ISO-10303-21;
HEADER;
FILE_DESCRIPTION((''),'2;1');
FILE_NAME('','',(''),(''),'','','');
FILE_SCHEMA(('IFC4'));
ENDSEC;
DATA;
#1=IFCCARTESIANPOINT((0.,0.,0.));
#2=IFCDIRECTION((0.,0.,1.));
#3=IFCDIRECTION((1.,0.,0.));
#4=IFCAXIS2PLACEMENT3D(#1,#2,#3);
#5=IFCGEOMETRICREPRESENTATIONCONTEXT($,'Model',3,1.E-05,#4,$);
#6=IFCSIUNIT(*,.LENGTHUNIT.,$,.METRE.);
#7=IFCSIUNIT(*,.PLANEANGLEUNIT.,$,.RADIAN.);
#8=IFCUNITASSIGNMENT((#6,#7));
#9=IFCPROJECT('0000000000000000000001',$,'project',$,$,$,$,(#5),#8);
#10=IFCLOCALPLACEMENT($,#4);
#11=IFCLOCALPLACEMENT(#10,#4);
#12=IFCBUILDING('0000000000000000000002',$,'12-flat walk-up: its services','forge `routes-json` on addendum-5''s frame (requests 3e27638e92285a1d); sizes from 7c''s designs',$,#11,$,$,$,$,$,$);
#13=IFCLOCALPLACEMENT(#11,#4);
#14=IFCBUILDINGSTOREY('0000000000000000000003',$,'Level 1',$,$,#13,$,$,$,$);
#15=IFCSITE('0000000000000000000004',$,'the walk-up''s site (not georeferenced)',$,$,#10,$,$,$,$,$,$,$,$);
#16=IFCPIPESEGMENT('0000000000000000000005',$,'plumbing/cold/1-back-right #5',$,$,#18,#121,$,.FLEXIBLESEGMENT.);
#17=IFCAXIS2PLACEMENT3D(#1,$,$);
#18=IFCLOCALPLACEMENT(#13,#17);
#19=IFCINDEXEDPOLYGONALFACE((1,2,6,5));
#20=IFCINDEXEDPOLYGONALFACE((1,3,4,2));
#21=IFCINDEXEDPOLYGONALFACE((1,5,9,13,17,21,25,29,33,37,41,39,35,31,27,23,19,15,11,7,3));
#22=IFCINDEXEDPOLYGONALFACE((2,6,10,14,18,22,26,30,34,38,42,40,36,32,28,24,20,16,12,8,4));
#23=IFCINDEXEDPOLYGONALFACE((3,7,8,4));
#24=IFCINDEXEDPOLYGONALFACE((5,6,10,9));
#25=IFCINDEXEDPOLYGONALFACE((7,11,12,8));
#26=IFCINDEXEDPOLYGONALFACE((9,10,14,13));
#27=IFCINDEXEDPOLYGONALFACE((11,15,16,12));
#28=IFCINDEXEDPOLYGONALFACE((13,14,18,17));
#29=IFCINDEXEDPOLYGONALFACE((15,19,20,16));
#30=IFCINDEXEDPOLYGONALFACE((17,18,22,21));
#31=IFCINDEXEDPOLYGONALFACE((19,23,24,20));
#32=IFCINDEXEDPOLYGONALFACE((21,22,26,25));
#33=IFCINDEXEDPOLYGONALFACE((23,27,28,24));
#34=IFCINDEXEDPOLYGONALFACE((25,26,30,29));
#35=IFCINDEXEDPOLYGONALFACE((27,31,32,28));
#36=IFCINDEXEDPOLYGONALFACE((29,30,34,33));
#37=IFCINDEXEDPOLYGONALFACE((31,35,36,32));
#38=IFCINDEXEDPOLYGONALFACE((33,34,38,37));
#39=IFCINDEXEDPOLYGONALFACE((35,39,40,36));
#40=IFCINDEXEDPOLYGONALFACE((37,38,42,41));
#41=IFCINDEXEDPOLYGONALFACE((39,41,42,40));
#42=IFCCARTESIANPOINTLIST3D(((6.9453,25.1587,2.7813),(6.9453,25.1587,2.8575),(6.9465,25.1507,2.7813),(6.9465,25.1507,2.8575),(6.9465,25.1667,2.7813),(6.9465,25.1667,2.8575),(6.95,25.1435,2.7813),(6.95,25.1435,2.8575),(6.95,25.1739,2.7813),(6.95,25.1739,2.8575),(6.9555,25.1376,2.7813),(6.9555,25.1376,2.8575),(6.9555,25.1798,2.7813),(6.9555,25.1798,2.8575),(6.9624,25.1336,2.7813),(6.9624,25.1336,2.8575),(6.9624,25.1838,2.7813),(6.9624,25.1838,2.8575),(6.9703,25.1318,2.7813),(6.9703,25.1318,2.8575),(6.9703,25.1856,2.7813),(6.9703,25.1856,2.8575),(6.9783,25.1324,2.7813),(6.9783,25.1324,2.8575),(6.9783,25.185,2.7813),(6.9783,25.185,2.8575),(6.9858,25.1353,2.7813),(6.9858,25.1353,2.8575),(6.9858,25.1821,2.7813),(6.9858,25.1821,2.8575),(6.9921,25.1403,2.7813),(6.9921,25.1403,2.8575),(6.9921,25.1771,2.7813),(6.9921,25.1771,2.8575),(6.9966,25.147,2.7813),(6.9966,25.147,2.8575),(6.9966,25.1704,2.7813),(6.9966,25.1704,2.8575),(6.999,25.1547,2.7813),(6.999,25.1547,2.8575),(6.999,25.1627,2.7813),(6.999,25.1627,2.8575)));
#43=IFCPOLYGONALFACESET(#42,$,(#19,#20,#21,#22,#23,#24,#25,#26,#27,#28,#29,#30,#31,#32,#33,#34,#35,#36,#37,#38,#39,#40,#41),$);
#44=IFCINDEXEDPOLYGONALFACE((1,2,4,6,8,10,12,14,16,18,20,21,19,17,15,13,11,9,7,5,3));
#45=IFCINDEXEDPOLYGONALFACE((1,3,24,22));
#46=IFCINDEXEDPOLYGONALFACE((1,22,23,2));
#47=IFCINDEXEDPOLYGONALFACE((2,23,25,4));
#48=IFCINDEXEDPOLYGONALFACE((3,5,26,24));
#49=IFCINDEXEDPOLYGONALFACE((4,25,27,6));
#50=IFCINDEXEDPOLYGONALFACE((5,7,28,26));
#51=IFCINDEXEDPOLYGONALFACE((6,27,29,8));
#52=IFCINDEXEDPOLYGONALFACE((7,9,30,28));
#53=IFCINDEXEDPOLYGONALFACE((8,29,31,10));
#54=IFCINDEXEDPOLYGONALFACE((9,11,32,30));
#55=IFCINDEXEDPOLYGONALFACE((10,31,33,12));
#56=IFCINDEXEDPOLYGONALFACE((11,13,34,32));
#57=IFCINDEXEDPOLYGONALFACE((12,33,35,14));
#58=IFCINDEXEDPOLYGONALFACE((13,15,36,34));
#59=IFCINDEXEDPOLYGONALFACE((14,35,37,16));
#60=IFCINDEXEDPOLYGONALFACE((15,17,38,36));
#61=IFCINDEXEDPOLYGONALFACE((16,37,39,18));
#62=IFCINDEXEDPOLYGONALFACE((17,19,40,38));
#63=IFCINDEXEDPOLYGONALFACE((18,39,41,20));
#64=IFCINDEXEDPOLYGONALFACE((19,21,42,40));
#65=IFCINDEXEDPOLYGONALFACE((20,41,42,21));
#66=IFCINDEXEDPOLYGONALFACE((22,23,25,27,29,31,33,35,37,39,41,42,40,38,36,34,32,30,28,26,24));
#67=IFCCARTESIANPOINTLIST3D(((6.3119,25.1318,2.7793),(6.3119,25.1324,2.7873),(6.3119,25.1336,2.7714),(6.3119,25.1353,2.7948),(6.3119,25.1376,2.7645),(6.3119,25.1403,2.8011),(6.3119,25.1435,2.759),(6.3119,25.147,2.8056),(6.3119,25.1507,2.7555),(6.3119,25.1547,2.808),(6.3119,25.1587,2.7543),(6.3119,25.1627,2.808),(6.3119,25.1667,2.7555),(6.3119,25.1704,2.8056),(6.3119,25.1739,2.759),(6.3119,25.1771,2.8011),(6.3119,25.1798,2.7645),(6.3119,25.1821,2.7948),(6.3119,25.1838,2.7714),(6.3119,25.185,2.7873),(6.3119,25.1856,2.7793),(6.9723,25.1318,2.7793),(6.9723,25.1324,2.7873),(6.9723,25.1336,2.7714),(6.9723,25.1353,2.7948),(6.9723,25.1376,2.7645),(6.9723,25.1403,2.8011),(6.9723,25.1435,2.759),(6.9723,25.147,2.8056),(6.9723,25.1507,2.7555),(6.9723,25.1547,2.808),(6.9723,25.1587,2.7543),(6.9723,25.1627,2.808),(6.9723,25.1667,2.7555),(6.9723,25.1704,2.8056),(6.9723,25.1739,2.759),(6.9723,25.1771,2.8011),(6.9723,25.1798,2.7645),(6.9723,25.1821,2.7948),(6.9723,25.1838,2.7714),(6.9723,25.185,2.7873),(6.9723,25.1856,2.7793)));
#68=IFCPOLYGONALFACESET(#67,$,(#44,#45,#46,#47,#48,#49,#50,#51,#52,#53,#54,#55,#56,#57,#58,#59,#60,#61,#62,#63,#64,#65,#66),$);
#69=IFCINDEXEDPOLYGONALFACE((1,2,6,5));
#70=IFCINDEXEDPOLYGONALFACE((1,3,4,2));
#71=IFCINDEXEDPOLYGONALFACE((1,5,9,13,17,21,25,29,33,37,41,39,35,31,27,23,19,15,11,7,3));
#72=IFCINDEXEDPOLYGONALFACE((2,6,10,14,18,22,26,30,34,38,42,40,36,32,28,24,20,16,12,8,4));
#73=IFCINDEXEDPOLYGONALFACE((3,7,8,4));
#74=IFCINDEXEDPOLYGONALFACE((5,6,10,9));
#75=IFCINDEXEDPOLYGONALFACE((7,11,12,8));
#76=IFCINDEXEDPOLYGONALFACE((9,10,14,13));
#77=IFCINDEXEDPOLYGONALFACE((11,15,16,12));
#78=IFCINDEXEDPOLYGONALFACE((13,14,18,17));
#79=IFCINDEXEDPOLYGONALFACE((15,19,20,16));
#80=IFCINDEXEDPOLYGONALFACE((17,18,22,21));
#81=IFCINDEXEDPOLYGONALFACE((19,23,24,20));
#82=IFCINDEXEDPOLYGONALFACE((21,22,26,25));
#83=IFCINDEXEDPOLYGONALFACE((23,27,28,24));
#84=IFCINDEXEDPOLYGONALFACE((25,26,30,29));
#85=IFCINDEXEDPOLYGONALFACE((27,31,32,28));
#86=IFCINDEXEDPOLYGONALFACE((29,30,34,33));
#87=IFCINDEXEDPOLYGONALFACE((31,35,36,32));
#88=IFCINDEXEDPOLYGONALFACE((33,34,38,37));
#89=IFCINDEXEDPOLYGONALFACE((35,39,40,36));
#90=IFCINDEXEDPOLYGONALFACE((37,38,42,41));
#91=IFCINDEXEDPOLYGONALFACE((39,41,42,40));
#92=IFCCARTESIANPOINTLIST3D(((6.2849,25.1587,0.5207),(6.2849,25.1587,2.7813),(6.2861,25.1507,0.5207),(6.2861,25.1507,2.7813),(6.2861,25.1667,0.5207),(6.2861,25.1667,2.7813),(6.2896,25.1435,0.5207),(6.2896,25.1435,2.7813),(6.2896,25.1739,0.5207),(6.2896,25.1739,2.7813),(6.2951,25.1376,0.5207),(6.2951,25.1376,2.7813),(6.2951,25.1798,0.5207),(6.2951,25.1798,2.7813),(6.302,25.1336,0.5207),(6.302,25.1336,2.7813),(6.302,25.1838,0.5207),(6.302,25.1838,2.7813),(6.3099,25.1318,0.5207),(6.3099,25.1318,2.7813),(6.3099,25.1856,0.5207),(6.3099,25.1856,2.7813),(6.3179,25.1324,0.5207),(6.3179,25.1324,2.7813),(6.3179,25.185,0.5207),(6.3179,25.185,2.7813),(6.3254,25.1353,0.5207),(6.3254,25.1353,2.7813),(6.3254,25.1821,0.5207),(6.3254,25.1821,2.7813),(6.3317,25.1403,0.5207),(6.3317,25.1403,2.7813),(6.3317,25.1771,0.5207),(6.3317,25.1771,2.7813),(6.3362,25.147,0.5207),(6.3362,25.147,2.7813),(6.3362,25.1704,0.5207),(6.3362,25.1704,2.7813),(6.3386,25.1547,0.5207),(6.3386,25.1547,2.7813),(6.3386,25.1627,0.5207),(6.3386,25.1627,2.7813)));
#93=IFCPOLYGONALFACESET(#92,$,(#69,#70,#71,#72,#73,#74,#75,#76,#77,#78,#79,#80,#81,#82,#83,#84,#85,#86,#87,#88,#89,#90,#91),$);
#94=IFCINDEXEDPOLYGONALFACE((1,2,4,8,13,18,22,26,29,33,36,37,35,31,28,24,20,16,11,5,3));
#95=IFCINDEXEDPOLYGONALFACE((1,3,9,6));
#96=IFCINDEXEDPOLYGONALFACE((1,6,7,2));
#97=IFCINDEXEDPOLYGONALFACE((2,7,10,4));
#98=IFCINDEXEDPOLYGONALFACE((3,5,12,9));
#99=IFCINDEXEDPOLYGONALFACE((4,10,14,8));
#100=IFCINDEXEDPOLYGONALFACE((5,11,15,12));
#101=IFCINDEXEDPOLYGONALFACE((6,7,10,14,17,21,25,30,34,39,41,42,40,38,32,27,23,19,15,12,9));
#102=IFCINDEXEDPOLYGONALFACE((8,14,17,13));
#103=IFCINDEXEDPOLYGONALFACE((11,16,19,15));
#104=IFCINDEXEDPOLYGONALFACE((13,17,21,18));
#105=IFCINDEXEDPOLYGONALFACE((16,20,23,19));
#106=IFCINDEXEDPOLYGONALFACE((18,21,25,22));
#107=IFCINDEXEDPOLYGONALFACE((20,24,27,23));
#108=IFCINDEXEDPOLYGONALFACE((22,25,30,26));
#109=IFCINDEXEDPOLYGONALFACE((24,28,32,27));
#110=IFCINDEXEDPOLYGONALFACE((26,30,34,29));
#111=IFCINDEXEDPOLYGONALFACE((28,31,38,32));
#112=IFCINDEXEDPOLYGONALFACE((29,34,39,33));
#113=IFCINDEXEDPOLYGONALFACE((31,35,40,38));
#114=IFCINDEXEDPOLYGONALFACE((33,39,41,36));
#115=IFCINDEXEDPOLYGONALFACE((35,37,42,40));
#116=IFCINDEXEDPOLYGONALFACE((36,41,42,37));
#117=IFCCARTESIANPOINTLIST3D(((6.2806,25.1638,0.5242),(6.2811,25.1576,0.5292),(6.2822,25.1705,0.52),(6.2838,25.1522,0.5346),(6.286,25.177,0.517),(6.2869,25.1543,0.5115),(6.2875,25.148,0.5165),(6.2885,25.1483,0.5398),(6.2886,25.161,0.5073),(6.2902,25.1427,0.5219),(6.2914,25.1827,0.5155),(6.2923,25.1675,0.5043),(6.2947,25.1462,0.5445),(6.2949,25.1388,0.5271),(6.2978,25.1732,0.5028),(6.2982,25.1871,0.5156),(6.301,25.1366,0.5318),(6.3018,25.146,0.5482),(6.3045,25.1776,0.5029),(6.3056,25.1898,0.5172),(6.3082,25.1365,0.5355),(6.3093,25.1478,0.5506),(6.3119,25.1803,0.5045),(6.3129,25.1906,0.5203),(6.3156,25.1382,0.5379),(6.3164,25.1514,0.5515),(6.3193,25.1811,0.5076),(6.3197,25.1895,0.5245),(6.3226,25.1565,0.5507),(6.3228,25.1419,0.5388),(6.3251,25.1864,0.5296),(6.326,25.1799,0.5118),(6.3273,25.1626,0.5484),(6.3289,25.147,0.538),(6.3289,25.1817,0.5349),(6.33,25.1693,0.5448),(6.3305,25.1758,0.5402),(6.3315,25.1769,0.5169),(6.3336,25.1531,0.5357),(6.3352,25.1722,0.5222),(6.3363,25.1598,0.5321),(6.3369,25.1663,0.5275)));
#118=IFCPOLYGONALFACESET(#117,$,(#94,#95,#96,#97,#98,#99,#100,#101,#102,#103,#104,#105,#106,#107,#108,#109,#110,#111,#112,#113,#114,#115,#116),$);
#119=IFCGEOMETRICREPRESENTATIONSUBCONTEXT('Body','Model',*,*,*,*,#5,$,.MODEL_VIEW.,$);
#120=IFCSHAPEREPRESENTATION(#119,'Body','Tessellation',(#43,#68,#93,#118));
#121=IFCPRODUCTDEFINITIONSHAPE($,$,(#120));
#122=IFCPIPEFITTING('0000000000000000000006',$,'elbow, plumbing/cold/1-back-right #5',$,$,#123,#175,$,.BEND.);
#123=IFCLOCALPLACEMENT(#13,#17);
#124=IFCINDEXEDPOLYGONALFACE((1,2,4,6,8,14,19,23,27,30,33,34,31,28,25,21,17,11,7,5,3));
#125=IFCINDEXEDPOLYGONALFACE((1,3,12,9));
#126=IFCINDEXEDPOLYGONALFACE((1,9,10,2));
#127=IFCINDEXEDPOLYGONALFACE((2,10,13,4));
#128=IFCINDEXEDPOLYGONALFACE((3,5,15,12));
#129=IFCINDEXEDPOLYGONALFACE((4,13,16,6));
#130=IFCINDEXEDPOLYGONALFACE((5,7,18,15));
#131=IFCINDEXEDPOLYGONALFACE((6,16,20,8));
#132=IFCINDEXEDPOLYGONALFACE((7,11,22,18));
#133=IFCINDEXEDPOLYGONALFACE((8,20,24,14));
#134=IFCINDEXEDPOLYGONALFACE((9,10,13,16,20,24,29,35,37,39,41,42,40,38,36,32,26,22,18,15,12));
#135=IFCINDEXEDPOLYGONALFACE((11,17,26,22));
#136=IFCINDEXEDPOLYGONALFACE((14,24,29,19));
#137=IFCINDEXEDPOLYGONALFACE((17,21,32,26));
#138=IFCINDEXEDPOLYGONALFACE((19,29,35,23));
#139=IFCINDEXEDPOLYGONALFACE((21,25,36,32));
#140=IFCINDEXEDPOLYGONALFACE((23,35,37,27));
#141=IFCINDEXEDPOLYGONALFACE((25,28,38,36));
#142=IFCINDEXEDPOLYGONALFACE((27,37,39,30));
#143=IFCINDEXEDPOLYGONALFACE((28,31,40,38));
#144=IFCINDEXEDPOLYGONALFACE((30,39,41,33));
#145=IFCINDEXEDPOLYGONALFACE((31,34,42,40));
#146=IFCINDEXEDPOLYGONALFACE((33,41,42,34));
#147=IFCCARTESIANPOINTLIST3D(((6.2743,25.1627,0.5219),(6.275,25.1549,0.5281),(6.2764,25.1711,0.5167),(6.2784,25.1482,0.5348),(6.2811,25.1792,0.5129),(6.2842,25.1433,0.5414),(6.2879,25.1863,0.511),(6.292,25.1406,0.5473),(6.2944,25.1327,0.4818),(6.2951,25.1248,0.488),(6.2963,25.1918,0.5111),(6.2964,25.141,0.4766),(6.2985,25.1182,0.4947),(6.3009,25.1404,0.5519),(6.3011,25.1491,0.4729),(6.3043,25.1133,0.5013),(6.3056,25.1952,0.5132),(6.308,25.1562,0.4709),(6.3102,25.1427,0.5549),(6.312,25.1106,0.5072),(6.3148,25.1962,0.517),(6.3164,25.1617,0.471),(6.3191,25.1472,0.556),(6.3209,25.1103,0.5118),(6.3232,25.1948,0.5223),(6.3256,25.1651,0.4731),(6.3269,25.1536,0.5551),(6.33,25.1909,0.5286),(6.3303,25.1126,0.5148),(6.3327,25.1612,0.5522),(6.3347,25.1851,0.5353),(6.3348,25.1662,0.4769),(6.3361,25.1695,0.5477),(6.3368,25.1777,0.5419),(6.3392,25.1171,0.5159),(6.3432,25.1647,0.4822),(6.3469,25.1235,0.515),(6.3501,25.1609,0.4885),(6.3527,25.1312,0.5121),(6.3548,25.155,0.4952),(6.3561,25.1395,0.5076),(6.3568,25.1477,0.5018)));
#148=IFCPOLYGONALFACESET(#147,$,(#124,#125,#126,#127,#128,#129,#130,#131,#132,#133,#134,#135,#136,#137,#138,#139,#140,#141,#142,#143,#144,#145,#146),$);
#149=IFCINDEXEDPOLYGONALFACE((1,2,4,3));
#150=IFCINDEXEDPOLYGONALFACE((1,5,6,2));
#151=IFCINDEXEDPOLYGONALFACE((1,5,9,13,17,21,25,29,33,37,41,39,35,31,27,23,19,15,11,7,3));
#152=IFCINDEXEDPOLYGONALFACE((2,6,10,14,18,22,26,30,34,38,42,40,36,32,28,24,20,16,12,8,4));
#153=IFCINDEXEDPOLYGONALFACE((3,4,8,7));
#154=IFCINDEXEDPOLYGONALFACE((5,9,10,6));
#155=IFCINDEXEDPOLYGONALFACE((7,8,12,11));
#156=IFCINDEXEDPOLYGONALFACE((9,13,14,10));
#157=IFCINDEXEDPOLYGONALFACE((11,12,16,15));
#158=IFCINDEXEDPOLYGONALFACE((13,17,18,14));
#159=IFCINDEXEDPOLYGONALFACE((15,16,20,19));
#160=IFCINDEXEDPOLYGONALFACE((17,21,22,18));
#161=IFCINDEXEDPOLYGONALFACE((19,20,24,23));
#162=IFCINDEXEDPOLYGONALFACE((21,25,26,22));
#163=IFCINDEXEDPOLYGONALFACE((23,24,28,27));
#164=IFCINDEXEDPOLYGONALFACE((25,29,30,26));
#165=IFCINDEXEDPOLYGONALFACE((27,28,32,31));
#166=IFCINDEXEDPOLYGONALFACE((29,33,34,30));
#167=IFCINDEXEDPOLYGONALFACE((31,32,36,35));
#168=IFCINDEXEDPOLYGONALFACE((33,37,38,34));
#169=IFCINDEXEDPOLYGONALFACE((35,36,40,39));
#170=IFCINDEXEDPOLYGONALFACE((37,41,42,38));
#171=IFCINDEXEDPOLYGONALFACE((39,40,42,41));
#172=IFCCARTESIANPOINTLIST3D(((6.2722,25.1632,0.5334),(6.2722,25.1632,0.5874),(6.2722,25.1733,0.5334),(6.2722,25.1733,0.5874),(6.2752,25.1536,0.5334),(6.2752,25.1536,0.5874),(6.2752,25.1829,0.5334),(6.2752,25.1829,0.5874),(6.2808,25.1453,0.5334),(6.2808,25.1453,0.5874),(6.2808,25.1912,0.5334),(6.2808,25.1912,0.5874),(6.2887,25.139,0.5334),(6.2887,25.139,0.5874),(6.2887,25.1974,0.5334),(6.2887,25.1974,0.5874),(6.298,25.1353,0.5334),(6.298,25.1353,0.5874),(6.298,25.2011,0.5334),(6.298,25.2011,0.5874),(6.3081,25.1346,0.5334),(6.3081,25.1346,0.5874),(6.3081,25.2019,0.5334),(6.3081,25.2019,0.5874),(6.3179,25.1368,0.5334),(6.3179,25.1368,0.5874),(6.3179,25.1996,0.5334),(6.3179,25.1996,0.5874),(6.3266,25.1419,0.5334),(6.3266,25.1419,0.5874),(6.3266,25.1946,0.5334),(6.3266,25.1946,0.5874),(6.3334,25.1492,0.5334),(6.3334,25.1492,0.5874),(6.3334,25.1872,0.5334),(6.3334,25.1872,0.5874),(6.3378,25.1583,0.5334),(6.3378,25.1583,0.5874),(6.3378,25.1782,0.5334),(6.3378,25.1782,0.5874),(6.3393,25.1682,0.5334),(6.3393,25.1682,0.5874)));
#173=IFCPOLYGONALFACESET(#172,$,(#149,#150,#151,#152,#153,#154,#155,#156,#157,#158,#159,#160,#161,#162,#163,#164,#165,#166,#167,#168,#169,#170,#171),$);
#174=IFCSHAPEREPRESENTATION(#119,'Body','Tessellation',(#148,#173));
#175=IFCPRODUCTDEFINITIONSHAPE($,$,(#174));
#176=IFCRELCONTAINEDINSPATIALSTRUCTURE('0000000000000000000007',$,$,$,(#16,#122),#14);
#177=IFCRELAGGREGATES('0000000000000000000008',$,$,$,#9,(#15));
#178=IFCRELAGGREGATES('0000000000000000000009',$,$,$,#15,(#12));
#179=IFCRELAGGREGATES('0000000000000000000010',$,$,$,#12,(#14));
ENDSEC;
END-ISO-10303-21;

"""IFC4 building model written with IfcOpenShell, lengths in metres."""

from ifc_helpers import new_model, entity, si_unit, frame, origin_with_axes, place, context, subcontext, project, spatial, element, save


model = new_model("IFC4")

# Units and contexts
model_context = context("Model", 3, precision=1e-05, world=origin_with_axes())
body_context = subcontext(model_context, "Body", "Model", "MODEL_VIEW")
ifc_project = project(units=[si_unit("LENGTHUNIT", "METRE"), si_unit("PLANEANGLEUNIT", "RADIAN")], contexts=[model_context])

# Site, building, storey
site_placement = place(None, origin_with_axes())
site = spatial("IfcSite", under=ifc_project, at=site_placement, Name="the walk-up's site (not georeferenced)")
building_placement = place(site_placement, origin_with_axes())
building = spatial("IfcBuilding", under=site, at=building_placement, Name="12-flat walk-up: its services", Description="forge `routes-json` on addendum-5's frame (requests 3e27638e92285a1d); sizes from 7c's designs")
storey_placement = place(building_placement, origin_with_axes())
storey = spatial("IfcBuildingStorey", under=building, at=storey_placement, Name="Level 1")

# Pipe segment
pipe_segment_1_placement = place(storey_placement, frame((6.9723, 25.1587, 2.8575), z_axis=(0.0, 0.0, 1.0), x_axis=(1.0, 0.0, 0.0)))
element("IfcPipeSegment", 1, at=pipe_segment_1_placement, inside=storey, Name="plumbing/cold/1-back-right #5", PredefinedType="FLEXIBLESEGMENT", context=body_context, shape_type="AdvancedSweptSolid", body=[
    entity("IfcSweptDiskSolid", entity("IfcPolyline", [entity("IfcCartesianPoint", [0.0, 0.0, 0.0]), entity("IfcCartesianPoint", [0.0, 0.0, -0.0762])]), 0.027),
    entity("IfcSweptDiskSolid", entity("IfcPolyline", [entity("IfcCartesianPoint", [0.0, 0.0, -0.0762]), entity("IfcCartesianPoint", [-0.6604, 0.0, -0.0762])]), 0.027),
    entity("IfcSweptDiskSolid", entity("IfcPolyline", [entity("IfcCartesianPoint", [-0.6604, 0.0, -0.0762]), entity("IfcCartesianPoint", [-0.6604, 0.0, -2.3368])]), 0.027),
    entity("IfcSweptDiskSolid", entity("IfcPolyline", [entity("IfcCartesianPoint", [-0.6604, 0.0, -2.3368]), entity("IfcCartesianPoint", [-0.6667, 0.0095, -2.3241])]), 0.027),
])

# Pipe fitting
pipe_fitting_1_placement = place(storey_placement, frame((6.3256, 25.1382, 0.4933), z_axis=(0.0, 0.0, 1.0), x_axis=(1.0, 0.0, 0.0)))
element("IfcPipeFitting", 2, at=pipe_fitting_1_placement, inside=storey, Name="elbow, plumbing/cold/1-back-right #5", PredefinedType="BEND", context=body_context, shape_type="AdvancedSweptSolid", body=[
    entity("IfcSweptDiskSolid", entity("IfcPolyline", [entity("IfcCartesianPoint", [0.0, 0.0, 0.0]), entity("IfcCartesianPoint", [-0.02, 0.0301, 0.0401])]), 0.0337),
    entity("IfcSweptDiskSolid", entity("IfcPolyline", [entity("IfcCartesianPoint", [-0.02, 0.0301, 0.0401]), entity("IfcCartesianPoint", [-0.02, 0.0301, 0.0941])]), 0.0337),
])

save(model, "model.ifc")
